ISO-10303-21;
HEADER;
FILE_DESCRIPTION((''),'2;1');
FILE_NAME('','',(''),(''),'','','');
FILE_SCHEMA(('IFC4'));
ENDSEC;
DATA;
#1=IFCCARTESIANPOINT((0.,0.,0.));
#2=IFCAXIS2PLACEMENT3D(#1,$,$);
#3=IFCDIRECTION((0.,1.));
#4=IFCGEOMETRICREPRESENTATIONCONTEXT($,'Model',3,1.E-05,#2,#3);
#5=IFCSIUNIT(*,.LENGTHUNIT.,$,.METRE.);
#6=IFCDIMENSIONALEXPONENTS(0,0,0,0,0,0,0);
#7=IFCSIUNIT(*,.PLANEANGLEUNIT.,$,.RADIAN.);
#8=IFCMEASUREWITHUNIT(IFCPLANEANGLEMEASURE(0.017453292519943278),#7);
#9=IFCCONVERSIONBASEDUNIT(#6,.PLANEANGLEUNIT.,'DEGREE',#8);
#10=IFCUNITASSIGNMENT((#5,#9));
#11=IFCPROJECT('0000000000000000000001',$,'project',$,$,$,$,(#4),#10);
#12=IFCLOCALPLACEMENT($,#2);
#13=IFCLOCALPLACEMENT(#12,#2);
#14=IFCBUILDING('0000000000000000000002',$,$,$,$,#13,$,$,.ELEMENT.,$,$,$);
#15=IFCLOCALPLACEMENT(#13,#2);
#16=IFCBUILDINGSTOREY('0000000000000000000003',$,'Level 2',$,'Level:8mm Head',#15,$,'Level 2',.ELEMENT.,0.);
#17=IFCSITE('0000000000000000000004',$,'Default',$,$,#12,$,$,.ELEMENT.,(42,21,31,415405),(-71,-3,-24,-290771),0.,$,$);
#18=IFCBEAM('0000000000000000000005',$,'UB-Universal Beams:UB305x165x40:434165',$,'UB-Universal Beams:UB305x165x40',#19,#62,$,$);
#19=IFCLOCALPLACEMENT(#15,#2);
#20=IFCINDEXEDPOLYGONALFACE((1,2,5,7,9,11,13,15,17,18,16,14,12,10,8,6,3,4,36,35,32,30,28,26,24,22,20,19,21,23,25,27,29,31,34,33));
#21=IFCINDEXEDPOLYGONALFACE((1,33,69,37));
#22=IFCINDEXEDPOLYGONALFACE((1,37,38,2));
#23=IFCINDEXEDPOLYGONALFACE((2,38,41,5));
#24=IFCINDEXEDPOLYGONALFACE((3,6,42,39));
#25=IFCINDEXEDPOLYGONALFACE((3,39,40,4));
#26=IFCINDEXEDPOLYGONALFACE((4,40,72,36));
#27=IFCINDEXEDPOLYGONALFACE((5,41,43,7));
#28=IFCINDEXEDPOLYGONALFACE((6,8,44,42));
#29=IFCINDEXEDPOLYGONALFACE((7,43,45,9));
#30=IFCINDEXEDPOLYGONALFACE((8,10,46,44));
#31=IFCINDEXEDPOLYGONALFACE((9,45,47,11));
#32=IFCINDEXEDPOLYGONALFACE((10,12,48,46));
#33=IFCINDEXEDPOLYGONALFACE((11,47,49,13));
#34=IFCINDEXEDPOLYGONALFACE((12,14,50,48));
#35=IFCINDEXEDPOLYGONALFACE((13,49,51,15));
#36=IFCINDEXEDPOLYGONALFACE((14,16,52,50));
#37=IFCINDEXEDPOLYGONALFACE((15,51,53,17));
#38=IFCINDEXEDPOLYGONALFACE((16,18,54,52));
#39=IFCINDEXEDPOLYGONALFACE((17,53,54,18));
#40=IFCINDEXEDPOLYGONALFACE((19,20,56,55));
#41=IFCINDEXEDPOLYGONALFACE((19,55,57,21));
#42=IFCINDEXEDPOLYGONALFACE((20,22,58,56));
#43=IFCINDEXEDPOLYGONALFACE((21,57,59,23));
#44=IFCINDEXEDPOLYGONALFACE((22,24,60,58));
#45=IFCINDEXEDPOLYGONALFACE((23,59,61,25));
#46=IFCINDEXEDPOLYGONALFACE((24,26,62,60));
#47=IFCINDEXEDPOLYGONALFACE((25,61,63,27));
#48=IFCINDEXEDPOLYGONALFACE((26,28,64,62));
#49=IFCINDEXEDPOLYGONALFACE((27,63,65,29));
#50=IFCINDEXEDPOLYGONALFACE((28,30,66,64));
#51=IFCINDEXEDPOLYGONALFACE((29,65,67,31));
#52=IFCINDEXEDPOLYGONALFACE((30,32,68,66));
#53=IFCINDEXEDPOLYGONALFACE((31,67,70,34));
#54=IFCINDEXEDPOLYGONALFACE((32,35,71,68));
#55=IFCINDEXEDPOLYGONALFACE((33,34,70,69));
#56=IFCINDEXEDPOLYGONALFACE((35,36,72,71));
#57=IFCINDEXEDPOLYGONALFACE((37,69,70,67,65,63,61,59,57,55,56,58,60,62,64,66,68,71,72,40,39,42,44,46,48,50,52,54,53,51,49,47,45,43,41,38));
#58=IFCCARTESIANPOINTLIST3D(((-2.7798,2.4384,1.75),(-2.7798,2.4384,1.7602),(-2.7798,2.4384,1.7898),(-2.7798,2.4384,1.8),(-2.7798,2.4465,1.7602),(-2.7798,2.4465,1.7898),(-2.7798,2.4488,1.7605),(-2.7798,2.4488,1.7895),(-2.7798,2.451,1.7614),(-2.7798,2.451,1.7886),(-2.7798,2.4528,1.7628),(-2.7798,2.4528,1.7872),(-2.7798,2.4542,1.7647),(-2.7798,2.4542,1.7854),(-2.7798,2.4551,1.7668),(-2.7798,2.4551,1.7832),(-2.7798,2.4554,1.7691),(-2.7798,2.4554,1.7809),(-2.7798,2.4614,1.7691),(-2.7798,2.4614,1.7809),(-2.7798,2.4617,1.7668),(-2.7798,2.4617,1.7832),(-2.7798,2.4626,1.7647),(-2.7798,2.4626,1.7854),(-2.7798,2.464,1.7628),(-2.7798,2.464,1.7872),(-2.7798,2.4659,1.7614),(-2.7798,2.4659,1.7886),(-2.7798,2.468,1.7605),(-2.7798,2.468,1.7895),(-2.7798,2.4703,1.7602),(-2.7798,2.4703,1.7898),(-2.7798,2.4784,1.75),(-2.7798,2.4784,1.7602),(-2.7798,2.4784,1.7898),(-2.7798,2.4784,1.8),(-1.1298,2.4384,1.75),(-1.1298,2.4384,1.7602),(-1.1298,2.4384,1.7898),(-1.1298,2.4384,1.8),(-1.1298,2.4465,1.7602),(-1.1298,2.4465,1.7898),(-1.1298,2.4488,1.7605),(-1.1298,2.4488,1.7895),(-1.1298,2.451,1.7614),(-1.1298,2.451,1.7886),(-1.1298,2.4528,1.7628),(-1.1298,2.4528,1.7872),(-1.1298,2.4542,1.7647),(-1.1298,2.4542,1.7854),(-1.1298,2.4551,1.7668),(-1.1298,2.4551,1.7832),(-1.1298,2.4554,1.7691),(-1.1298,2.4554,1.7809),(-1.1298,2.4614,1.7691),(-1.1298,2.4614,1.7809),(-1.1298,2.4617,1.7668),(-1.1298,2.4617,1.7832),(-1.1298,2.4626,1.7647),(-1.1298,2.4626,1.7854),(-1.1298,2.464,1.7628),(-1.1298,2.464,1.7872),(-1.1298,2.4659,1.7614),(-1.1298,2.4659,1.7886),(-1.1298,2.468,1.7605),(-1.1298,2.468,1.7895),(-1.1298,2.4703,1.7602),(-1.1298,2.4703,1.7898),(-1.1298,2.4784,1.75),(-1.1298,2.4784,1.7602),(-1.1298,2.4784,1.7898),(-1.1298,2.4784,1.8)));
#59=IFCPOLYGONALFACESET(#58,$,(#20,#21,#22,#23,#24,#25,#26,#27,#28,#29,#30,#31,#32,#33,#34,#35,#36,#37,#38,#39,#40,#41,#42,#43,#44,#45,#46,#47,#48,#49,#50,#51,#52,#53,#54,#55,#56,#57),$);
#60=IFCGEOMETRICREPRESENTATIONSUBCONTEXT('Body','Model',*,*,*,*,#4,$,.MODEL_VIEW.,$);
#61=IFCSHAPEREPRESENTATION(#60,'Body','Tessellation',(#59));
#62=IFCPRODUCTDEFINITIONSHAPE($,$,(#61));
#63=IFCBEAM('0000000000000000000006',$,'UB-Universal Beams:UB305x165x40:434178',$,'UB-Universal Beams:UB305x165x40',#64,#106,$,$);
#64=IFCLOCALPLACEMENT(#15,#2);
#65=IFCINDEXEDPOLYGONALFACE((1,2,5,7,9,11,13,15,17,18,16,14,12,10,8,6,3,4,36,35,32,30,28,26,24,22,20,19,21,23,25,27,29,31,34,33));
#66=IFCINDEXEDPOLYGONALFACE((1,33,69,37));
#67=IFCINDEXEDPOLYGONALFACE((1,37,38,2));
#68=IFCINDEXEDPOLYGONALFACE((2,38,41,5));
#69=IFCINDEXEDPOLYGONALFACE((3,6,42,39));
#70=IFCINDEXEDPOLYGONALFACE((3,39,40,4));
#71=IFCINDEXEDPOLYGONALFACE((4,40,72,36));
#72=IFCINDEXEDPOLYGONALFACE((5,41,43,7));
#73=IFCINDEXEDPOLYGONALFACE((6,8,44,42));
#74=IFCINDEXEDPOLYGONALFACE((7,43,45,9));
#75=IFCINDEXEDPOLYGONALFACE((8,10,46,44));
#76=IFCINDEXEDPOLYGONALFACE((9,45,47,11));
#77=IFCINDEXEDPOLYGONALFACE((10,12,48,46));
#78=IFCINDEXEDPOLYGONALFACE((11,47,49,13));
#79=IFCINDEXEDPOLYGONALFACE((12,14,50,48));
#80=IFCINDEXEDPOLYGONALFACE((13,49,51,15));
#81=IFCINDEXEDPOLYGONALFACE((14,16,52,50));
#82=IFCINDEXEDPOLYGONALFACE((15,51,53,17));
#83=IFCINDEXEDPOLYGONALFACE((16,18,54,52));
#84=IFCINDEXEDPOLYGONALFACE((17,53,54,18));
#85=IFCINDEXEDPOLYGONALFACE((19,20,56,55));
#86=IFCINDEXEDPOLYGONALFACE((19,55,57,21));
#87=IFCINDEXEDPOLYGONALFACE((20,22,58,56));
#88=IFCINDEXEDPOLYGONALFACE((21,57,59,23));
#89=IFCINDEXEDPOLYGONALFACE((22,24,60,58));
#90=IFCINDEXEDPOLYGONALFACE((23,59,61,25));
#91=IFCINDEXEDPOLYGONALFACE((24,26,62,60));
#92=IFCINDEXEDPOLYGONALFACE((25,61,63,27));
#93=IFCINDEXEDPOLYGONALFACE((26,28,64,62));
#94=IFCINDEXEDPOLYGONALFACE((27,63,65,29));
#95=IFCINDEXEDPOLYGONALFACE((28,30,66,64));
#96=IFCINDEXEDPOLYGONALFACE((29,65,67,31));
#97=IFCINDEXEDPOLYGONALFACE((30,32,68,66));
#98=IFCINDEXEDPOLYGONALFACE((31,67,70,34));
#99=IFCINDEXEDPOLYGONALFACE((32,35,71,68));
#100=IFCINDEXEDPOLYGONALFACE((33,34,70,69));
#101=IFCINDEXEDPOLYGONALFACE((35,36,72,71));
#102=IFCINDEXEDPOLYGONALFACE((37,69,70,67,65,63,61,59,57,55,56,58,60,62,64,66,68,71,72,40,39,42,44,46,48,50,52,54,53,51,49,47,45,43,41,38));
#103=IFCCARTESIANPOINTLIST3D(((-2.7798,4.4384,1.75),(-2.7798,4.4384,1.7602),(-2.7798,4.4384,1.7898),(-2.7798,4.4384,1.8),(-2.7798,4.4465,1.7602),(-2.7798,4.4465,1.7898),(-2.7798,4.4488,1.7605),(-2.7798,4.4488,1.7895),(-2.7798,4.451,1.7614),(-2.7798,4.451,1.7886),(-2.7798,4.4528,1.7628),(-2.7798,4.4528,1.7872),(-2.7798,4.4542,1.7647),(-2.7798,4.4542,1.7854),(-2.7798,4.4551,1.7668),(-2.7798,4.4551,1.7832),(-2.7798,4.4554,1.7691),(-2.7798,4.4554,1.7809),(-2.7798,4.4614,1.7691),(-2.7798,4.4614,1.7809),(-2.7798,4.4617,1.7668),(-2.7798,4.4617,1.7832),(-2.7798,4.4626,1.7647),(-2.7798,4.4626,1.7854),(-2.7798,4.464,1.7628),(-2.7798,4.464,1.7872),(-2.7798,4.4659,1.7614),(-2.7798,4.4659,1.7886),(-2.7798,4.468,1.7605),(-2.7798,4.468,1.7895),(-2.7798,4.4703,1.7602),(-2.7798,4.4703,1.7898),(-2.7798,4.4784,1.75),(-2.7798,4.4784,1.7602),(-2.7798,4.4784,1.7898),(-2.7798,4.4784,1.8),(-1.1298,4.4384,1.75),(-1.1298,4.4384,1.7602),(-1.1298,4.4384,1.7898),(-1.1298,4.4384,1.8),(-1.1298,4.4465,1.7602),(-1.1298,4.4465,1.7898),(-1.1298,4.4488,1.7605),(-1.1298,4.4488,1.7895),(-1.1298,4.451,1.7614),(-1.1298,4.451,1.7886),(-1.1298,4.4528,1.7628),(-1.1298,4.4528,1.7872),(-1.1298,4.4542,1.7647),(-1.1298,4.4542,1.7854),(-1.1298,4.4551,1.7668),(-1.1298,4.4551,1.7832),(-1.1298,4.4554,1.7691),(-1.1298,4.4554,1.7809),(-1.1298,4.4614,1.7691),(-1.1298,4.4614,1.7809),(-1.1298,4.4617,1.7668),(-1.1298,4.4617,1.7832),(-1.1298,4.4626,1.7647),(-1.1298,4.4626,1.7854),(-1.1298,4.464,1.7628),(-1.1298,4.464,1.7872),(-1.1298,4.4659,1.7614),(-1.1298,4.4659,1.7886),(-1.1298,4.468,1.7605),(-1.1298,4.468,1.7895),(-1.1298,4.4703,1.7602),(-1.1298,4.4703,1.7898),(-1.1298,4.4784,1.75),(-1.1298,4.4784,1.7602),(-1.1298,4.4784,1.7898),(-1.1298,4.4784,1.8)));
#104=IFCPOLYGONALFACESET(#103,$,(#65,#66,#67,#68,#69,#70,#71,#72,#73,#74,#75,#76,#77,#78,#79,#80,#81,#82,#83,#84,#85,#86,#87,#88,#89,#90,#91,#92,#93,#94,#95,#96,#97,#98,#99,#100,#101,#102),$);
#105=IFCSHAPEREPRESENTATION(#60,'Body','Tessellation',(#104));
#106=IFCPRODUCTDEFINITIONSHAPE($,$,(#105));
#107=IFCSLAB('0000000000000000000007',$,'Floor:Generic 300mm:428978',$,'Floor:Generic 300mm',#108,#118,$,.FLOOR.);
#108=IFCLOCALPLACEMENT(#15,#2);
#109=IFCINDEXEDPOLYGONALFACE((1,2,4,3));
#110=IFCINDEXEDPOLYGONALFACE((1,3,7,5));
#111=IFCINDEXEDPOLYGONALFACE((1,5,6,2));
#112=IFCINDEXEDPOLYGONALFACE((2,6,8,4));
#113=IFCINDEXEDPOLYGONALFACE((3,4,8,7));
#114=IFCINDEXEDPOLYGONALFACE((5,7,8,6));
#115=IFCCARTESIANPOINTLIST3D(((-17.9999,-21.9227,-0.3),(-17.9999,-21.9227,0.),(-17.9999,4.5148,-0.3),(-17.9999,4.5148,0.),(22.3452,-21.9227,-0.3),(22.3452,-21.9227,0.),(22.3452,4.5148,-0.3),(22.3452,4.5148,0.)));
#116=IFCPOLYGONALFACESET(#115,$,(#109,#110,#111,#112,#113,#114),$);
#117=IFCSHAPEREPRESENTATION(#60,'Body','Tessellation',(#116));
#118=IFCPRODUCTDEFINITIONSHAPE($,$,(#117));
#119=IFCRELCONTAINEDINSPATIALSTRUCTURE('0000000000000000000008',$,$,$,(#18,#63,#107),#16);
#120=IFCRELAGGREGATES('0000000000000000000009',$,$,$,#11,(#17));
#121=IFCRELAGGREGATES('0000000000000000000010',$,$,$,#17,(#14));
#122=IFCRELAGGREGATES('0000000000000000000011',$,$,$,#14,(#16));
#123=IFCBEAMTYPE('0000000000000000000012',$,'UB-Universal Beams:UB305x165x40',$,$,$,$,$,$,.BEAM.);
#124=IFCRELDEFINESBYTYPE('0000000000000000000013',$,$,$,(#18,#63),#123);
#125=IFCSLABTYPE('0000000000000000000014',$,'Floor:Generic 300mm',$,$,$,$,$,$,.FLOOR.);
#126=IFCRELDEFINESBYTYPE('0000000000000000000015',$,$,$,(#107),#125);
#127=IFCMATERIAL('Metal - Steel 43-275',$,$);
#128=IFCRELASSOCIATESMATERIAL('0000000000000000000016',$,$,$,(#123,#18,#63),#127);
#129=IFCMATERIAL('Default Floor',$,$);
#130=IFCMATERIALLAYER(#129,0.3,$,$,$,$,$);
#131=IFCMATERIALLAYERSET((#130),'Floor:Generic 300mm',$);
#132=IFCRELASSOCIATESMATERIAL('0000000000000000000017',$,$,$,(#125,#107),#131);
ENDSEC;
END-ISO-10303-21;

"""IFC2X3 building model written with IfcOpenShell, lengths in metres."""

from ifc_helpers import new_model, entity, si_unit, converted_unit, direction, frame, frame_2d, origin, origin_2d_with_axis, place, context, subcontext, project, spatial, rectangle, i_section, extrude, material, layer, layer_set, layer_usage, type_object, element, save


model = new_model("IFC2X3")

# Units and contexts
model_context = context("Model", 3, precision=1e-05, world=origin(), true_north=direction((0.0, 1.0)))
body_context = subcontext(model_context, "Body", "Model", "MODEL_VIEW")
ifc_project = project(units=[si_unit("LENGTHUNIT", "METRE"), converted_unit("PLANEANGLEUNIT", "DEGREE", entity("IfcPlaneAngleMeasure", 0.017453292519943278), si_unit("PLANEANGLEUNIT", "RADIAN"), dimensions=[0, 0, 0, 0, 0, 0, 0])], contexts=[model_context])

# Site, building, storey
site_placement = place(None, origin())
site = spatial("IfcSite", under=ifc_project, at=site_placement, Name="Default", CompositionType="ELEMENT", RefLatitude=(42, 21, 31, 415405), RefLongitude=(-71, -3, -24, -290771), RefElevation=0.0)
building_placement = place(site_placement, origin())
building = spatial("IfcBuilding", under=site, at=building_placement, CompositionType="ELEMENT")
storey_placement = place(building_placement, origin())
storey = spatial("IfcBuildingStorey", under=building, at=storey_placement, Name="Level 2", ObjectType="Level:8mm Head", LongName="Level 2", CompositionType="ELEMENT", Elevation=0.0)

# Shared definitions
ifc_material_1 = material(Name="Metal - Steel 43-275")

# Beams
beam_type = type_object("IfcBeamType", Name="UB-Universal Beams:UB305x165x40", PredefinedType="BEAM", material=ifc_material_1)
beam_1_placement = place(storey_placement, frame((-2.7798, 2.4584, 1.8)))
element("IfcBeam", 1, at=beam_1_placement, inside=storey, type_object=beam_type, material=ifc_material_1, Name="UB-Universal Beams:UB305x165x40:434165", ObjectType="UB-Universal Beams:UB305x165x40", context=body_context, shape_type="SweptSolid", body=[
    extrude(i_section(OverallWidth=0.04, OverallDepth=0.05, WebThickness=0.006, FlangeThickness=0.0102, FilletRadius=0.0089, at=frame_2d((0.0, 0.0), x_axis=(0.0, 1.0))), frame((0.0, 0.0, -0.025), z_axis=(1.0, 0.0, 0.0), x_axis=(0.0, 0.0, -1.0)), (0.0, 0.0, 1.0), 1.65),
])
beam_2_placement = place(storey_placement, frame((-2.7798, 4.4584, 1.8)))
element("IfcBeam", 2, at=beam_2_placement, inside=storey, type_object=beam_type, material=ifc_material_1, Name="UB-Universal Beams:UB305x165x40:434178", ObjectType="UB-Universal Beams:UB305x165x40", context=body_context, shape_type="SweptSolid", body=[
    extrude(i_section(OverallWidth=0.04, OverallDepth=0.05, WebThickness=0.006, FlangeThickness=0.0102, FilletRadius=0.0089, at=frame_2d((0.0, 0.0), x_axis=(0.0, 1.0))), frame((0.0, 0.0, -0.025), z_axis=(1.0, 0.0, 0.0), x_axis=(0.0, 0.0, -1.0)), (0.0, 0.0, 1.0), 1.65),
])

# Slab
ifc_material_2 = material(Name="Default Floor")
ifc_layer = layer(ifc_material_2, 0.3)
ifc_layer_set = layer_set([ifc_layer], Name="Floor:Generic 300mm")
ifc_layer_usage = layer_usage(ifc_layer_set, "AXIS3", "POSITIVE", 0.0)
slab_type = type_object("IfcSlabType", Name="Floor:Generic 300mm", PredefinedType="FLOOR", material=ifc_layer_set)
slab_placement = place(storey_placement, origin())
element("IfcSlab", 3, at=slab_placement, inside=storey, type_object=slab_type, material=ifc_layer_usage, Name="Floor:Generic 300mm:428978", ObjectType="Floor:Generic 300mm", PredefinedType="FLOOR", context=body_context, shape_type="SweptSolid", body=[
    extrude(rectangle(XDim=26.4375, YDim=40.3451, at=origin_2d_with_axis()), frame((2.1726, -8.704, 0.0), z_axis=(0.0, 0.0, -1.0), x_axis=(0.0, 1.0, 0.0)), (0.0, 0.0, 1.0), 0.3),
])

save(model, "model.ifc")
